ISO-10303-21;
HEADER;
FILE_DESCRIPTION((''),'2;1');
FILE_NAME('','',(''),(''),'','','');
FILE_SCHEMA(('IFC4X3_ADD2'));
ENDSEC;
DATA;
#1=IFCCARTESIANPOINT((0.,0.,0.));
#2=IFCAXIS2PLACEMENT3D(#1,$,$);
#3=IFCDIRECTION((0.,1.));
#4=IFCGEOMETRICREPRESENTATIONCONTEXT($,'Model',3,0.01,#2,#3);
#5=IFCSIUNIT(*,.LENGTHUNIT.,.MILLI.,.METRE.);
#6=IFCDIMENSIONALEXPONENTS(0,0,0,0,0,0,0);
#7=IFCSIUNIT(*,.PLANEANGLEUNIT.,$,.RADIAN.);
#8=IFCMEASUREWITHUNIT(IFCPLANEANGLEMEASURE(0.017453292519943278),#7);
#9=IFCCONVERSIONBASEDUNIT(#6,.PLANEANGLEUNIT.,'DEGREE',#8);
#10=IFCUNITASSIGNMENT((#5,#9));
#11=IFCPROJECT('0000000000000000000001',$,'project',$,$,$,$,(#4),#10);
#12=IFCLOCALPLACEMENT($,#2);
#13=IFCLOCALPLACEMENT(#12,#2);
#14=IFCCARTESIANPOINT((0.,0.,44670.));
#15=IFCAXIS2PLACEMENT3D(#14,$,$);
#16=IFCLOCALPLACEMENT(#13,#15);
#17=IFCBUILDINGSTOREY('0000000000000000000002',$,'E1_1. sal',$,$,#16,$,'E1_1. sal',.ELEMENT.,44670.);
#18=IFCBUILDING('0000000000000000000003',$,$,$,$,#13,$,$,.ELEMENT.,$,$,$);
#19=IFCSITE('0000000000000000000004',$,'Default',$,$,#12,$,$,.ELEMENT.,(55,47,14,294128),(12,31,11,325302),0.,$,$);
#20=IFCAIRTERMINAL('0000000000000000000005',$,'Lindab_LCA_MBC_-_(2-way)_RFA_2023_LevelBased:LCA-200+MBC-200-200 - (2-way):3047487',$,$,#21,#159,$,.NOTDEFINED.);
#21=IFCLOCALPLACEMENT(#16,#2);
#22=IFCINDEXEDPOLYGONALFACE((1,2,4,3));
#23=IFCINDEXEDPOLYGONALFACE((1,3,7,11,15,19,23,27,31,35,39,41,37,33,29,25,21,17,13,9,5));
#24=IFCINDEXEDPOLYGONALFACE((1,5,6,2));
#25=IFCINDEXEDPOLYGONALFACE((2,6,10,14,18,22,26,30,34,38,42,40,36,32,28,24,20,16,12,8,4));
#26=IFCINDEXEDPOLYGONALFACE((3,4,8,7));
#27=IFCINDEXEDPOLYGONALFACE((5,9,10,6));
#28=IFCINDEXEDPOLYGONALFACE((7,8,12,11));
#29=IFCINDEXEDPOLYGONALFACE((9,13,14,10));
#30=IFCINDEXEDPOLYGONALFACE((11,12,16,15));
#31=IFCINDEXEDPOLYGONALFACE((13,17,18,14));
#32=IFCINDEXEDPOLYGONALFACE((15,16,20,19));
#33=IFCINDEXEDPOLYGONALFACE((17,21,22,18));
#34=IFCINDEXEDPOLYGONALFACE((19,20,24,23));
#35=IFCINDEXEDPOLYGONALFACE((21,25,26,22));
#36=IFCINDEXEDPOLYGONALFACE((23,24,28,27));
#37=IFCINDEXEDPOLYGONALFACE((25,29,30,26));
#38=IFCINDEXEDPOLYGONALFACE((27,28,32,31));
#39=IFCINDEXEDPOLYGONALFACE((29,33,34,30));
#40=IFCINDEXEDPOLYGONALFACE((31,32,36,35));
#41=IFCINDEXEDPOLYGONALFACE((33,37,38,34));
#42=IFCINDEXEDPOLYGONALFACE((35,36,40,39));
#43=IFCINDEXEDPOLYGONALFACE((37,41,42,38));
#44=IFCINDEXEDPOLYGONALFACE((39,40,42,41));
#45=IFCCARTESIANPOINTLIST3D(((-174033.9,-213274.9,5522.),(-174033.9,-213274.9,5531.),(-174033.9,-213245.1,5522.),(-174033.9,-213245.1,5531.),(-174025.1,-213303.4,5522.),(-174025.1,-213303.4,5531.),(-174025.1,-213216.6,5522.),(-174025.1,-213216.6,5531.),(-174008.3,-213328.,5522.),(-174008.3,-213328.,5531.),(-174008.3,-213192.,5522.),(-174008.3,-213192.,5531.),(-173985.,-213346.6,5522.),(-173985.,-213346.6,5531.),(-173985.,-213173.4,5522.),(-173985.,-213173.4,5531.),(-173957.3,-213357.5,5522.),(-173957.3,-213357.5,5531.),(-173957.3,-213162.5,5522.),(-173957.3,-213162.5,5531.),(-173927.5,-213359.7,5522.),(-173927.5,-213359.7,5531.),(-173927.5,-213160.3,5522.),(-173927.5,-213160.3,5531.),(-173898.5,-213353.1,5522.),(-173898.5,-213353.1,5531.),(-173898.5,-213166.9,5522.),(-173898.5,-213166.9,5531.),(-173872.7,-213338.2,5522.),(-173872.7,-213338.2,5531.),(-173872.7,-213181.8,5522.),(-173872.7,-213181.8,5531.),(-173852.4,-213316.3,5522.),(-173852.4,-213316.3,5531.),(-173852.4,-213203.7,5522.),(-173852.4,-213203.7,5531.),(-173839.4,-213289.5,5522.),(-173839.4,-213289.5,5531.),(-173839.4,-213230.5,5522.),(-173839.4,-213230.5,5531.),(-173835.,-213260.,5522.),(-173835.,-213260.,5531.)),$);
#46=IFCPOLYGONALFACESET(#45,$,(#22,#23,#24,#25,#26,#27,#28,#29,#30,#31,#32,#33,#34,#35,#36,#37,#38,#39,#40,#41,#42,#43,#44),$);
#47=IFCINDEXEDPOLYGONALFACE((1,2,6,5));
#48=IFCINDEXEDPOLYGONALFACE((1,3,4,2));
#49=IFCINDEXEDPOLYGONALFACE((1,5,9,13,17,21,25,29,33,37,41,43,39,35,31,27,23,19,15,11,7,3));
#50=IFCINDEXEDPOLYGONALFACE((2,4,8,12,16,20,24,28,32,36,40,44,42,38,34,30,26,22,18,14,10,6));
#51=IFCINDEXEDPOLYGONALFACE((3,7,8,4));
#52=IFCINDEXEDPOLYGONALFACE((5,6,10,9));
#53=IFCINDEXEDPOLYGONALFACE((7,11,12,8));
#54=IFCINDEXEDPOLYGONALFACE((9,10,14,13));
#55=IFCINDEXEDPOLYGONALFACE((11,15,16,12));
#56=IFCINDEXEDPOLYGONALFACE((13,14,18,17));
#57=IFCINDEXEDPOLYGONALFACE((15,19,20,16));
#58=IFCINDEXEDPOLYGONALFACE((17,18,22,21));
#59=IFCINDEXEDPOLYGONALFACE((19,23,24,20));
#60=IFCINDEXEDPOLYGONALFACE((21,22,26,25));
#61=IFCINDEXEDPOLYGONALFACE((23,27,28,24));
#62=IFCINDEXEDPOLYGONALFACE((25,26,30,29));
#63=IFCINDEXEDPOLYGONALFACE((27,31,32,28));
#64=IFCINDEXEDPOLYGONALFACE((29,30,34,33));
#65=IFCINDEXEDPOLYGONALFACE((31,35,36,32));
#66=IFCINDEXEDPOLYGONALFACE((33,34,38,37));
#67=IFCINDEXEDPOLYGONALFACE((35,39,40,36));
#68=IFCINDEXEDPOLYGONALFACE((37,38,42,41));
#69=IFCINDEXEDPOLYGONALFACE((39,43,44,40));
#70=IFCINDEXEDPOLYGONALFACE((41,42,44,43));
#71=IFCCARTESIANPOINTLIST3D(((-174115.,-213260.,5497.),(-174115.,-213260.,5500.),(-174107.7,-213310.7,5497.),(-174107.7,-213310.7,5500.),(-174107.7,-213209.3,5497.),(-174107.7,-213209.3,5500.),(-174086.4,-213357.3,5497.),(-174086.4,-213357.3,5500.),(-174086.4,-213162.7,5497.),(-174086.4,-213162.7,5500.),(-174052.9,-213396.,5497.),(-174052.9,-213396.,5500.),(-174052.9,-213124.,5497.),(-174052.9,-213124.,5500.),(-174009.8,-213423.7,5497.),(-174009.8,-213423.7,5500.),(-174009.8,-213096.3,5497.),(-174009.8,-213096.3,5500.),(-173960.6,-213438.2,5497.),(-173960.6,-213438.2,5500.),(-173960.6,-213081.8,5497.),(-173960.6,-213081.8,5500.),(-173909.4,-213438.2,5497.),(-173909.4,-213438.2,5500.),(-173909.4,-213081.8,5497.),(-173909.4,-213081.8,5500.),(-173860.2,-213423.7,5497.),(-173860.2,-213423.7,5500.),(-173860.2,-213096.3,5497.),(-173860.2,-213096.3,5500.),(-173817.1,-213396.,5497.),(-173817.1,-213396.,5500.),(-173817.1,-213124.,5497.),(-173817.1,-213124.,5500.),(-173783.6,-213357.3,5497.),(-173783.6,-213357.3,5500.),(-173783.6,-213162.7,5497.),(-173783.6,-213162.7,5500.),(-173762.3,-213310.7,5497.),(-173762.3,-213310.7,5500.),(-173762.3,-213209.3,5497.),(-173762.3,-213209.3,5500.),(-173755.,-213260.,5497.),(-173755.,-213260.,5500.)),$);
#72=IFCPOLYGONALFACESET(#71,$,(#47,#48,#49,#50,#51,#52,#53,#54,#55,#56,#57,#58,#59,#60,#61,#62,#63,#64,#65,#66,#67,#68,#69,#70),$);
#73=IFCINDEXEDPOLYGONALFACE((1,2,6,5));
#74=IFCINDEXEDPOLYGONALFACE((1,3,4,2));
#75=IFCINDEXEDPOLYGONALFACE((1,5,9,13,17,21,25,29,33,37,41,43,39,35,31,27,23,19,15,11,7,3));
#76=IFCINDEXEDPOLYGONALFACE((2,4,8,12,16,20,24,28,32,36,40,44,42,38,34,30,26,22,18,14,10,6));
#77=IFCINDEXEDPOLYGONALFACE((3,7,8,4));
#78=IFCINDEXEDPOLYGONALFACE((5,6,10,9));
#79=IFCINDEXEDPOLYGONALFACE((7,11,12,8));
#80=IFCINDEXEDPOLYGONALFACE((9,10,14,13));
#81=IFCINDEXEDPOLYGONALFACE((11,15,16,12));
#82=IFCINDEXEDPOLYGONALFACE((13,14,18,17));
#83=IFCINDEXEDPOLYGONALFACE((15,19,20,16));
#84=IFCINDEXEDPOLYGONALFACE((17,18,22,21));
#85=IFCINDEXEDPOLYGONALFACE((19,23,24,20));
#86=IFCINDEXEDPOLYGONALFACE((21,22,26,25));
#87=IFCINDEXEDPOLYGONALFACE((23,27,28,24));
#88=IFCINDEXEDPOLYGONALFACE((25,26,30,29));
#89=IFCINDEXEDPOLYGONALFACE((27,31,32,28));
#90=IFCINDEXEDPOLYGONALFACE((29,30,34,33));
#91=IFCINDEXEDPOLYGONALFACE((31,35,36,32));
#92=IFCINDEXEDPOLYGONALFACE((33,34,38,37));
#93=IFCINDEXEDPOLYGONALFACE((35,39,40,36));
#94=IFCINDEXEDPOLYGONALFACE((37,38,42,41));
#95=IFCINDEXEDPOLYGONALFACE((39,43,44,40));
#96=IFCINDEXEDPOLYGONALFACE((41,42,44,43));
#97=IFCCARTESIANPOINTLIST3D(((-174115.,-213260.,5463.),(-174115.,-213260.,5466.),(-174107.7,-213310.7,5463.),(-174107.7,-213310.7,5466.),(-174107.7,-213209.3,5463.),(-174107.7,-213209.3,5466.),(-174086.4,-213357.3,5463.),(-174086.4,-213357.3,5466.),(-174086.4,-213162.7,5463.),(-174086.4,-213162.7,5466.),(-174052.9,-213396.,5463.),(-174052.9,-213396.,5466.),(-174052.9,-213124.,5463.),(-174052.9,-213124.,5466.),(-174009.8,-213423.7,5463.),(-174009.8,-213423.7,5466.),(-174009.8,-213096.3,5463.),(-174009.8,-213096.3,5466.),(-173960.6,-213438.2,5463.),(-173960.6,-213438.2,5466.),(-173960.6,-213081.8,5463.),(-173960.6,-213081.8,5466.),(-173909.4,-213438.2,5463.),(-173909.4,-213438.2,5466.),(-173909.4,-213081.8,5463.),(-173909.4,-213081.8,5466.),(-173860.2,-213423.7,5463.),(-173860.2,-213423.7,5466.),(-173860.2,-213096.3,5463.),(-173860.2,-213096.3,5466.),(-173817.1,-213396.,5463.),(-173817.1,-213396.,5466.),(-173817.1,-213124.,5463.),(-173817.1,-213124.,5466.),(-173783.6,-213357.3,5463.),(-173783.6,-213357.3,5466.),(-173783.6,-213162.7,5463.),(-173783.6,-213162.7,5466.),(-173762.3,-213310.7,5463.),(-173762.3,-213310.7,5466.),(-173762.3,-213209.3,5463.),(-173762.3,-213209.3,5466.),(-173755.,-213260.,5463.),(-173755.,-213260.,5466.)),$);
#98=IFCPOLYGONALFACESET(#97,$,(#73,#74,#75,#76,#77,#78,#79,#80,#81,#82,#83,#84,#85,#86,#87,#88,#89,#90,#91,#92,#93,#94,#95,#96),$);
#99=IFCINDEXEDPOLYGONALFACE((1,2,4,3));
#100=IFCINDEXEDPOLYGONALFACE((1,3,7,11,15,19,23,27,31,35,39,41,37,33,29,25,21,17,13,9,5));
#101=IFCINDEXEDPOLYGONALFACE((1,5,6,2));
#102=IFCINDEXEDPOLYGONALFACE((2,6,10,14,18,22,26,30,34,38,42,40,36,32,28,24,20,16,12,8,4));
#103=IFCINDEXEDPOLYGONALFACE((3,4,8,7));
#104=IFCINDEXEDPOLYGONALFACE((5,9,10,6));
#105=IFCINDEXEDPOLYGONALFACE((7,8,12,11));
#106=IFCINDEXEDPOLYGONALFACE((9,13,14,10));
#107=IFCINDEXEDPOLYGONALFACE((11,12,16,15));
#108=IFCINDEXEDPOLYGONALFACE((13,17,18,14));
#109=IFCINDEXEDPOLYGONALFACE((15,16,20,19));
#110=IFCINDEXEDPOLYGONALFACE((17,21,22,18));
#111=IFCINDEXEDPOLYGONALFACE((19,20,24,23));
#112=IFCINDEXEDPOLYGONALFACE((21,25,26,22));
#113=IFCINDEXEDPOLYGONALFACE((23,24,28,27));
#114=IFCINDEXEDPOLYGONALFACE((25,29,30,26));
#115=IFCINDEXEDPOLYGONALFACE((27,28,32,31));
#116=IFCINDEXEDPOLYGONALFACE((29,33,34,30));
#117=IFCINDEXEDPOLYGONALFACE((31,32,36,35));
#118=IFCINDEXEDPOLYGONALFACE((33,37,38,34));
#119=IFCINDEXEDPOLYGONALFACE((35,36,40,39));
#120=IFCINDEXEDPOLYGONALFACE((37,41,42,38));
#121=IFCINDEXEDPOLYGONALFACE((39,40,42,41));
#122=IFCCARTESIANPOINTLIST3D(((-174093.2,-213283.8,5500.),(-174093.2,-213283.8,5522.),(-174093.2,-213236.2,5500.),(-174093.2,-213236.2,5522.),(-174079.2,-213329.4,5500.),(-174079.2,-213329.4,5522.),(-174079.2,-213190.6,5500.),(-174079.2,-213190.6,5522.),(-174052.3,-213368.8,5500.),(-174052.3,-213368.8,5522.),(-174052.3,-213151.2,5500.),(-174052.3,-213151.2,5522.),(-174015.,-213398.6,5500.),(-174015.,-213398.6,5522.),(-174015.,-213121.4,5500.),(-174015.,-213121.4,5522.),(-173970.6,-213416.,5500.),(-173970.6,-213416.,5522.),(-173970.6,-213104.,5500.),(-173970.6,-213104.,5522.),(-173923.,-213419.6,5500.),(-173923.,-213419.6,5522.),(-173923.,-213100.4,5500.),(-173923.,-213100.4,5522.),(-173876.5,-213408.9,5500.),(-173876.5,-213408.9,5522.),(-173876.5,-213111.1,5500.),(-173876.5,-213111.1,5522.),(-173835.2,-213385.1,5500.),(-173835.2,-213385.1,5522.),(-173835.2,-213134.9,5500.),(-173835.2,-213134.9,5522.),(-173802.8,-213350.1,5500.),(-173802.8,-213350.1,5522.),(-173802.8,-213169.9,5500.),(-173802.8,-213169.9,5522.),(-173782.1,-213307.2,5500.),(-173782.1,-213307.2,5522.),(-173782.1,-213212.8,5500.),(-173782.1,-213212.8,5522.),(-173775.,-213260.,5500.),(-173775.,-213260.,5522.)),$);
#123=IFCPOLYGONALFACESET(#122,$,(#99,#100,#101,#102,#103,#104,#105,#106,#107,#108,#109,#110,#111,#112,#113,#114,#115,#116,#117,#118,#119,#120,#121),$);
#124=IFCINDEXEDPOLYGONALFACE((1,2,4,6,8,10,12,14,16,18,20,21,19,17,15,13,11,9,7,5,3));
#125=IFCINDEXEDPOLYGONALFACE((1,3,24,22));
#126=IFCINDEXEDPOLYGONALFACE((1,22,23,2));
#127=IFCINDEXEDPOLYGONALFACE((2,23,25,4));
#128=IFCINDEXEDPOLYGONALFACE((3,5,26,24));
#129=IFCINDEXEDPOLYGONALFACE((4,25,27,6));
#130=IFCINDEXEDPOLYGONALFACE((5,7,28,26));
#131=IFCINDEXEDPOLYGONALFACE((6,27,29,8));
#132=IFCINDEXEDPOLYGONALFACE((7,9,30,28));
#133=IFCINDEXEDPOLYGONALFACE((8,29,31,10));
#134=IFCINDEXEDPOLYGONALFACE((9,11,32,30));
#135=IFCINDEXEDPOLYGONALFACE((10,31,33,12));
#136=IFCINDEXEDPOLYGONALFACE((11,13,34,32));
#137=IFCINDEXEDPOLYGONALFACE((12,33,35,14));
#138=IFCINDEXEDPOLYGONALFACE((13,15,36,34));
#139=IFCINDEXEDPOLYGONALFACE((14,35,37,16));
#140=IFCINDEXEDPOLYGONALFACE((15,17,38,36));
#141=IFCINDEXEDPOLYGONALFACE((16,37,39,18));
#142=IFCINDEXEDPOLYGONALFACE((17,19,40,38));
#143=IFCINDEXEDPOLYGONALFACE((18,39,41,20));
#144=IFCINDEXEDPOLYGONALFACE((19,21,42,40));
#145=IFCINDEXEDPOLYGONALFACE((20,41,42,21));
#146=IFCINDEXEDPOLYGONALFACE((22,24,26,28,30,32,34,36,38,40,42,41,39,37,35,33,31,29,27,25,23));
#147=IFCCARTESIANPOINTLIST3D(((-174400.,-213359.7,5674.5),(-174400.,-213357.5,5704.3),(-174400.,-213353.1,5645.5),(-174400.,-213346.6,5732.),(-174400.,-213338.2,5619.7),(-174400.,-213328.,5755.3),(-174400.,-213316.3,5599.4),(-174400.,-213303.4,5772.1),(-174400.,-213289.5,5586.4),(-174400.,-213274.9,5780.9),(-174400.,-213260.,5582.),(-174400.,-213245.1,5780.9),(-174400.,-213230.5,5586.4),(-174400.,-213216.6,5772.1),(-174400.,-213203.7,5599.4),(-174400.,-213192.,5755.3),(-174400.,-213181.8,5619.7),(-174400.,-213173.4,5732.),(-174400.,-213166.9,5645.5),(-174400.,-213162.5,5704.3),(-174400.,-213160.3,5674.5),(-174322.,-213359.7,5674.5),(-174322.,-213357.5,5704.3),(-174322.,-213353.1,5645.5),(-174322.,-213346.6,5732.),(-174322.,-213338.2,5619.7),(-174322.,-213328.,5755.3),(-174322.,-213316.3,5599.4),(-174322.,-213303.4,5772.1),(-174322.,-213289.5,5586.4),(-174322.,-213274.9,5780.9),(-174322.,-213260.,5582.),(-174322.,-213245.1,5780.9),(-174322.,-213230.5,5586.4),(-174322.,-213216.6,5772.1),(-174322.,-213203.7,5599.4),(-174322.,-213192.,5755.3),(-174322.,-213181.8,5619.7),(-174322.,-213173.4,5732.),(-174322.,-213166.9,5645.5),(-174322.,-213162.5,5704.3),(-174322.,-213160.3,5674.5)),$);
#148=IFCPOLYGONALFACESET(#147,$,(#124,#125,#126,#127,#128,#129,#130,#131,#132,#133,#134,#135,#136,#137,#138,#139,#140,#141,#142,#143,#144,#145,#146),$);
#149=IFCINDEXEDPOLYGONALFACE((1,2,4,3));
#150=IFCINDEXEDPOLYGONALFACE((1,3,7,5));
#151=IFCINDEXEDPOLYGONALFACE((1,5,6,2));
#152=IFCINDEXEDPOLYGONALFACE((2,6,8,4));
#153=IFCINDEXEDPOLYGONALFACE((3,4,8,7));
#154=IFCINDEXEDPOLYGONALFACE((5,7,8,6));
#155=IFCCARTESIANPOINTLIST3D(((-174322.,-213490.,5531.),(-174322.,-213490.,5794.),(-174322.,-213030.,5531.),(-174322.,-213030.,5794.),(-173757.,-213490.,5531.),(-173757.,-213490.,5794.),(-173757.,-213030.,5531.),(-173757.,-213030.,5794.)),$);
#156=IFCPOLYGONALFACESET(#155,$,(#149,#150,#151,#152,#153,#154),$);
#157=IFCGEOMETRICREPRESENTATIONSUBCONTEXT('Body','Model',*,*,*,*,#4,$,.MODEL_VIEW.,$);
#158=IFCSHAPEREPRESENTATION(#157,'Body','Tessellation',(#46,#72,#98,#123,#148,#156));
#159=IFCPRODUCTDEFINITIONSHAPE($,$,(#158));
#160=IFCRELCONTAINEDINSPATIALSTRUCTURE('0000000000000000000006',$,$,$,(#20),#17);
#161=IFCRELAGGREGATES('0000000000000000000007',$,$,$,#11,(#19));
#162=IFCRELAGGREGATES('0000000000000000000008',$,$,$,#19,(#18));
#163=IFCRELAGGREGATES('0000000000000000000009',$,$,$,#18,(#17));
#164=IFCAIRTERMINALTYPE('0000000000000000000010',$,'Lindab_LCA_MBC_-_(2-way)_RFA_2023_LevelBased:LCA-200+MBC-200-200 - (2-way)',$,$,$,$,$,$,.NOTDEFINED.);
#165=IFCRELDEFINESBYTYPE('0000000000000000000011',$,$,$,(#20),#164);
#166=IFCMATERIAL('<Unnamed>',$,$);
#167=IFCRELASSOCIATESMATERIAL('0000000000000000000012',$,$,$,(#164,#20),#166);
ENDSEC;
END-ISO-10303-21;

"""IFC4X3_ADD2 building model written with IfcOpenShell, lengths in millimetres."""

from ifc_helpers import new_model, entity, si_unit, converted_unit, direction, frame, frame_2d, origin, origin_2d_with_axis, place, context, subcontext, project, spatial, rectangle, circle, extrude, source, transform, mapped, material, type_object, type_shapes, element, save


model = new_model("IFC4X3_ADD2")

# Units and contexts
model_context = context("Model", 3, precision=0.01, world=origin(), true_north=direction((0.0, 1.0)))
body_context = subcontext(model_context, "Body", "Model", "MODEL_VIEW")
ifc_project = project(units=[si_unit("LENGTHUNIT", "METRE", prefix="MILLI"), converted_unit("PLANEANGLEUNIT", "DEGREE", entity("IfcPlaneAngleMeasure", 0.017453292519943278), si_unit("PLANEANGLEUNIT", "RADIAN"), dimensions=[0, 0, 0, 0, 0, 0, 0])], contexts=[model_context])

# Site, building, storey
site_placement = place(None, origin())
site = spatial("IfcSite", under=ifc_project, at=site_placement, Name="Default", CompositionType="ELEMENT", RefLatitude=(55, 47, 14, 294128), RefLongitude=(12, 31, 11, 325302), RefElevation=0.0)
building_placement = place(site_placement, origin())
building = spatial("IfcBuilding", under=site, at=building_placement, CompositionType="ELEMENT")
storey_placement = place(building_placement, frame((0.0, 0.0, 44670.0)))
storey = spatial("IfcBuildingStorey", under=building, at=storey_placement, Name="E1_1. sal", LongName="E1_1. sal", CompositionType="ELEMENT", Elevation=44670.0)

# Air terminal
ifc_material_1 = material(Name="<Unnamed>")
air_terminal_type_1 = type_object("IfcAirTerminalType", Name="Lindab_LCA_MBC_-_(2-way)_RFA_2023_LevelBased:LCA-200+MBC-200-200 - (2-way)", PredefinedType="NOTDEFINED", material=ifc_material_1)
shared_shape_1 = source(origin(), body_context, "Body", "SweptSolid", [
    extrude(circle(Radius=100.0, at=frame_2d((0.0, 0.0), x_axis=(1.0, 0.0))), frame((0.0, 0.0, 22.0)), (0.0, 0.0, 1.0), 9.0),
    extrude(circle(Radius=180.0, at=frame_2d((0.0, 0.0), x_axis=(1.0, 0.0))), frame((0.0, 0.0, -3.0)), (0.0, 0.0, 1.0), 3.0),
    extrude(circle(Radius=180.0, at=frame_2d((0.0, 0.0), x_axis=(1.0, 0.0))), frame((0.0, 0.0, -37.0)), (0.0, 0.0, 1.0), 3.0),
    extrude(circle(Radius=160.0, at=frame_2d((0.0, 0.0), x_axis=(1.0, 0.0))), origin(), (0.0, 0.0, 1.0), 22.0),
    extrude(circle(Radius=100.0, at=frame_2d((0.0, 0.0), x_axis=(1.0, 0.0))), frame((-465.0, 0.0, 182.0), z_axis=(1.0, 0.0, 0.0), x_axis=(0.0, 0.0, -1.0)), (0.0, 0.0, 1.0), 78.0),
    extrude(rectangle(XDim=460.0, YDim=565.0, at=origin_2d_with_axis()), frame((-104.5, 0.0, 31.0), z_axis=(0.0, 0.0, 1.0), x_axis=(0.0, -1.0, 0.0)), (0.0, 0.0, 1.0), 263.0),
])
type_shapes(air_terminal_type_1, [shared_shape_1])
for number, where, name in (
    (1, (-173935.0, -213260.0, 5500.0), "Lindab_LCA_MBC_-_(2-way)_RFA_2023_LevelBased:LCA-200+MBC-200-200 - (2-way):3047487"),
):
    element("IfcAirTerminal", number, at=place(storey_placement, frame(where)), inside=storey, type_object=air_terminal_type_1, material=ifc_material_1, Name=name, PredefinedType="NOTDEFINED", context=body_context, shape_type="MappedRepresentation", body=[
        mapped(shared_shape_1, transform((0.0, 0.0, 0.0), scale=1.0)),
    ])

save(model, "model.ifc")
